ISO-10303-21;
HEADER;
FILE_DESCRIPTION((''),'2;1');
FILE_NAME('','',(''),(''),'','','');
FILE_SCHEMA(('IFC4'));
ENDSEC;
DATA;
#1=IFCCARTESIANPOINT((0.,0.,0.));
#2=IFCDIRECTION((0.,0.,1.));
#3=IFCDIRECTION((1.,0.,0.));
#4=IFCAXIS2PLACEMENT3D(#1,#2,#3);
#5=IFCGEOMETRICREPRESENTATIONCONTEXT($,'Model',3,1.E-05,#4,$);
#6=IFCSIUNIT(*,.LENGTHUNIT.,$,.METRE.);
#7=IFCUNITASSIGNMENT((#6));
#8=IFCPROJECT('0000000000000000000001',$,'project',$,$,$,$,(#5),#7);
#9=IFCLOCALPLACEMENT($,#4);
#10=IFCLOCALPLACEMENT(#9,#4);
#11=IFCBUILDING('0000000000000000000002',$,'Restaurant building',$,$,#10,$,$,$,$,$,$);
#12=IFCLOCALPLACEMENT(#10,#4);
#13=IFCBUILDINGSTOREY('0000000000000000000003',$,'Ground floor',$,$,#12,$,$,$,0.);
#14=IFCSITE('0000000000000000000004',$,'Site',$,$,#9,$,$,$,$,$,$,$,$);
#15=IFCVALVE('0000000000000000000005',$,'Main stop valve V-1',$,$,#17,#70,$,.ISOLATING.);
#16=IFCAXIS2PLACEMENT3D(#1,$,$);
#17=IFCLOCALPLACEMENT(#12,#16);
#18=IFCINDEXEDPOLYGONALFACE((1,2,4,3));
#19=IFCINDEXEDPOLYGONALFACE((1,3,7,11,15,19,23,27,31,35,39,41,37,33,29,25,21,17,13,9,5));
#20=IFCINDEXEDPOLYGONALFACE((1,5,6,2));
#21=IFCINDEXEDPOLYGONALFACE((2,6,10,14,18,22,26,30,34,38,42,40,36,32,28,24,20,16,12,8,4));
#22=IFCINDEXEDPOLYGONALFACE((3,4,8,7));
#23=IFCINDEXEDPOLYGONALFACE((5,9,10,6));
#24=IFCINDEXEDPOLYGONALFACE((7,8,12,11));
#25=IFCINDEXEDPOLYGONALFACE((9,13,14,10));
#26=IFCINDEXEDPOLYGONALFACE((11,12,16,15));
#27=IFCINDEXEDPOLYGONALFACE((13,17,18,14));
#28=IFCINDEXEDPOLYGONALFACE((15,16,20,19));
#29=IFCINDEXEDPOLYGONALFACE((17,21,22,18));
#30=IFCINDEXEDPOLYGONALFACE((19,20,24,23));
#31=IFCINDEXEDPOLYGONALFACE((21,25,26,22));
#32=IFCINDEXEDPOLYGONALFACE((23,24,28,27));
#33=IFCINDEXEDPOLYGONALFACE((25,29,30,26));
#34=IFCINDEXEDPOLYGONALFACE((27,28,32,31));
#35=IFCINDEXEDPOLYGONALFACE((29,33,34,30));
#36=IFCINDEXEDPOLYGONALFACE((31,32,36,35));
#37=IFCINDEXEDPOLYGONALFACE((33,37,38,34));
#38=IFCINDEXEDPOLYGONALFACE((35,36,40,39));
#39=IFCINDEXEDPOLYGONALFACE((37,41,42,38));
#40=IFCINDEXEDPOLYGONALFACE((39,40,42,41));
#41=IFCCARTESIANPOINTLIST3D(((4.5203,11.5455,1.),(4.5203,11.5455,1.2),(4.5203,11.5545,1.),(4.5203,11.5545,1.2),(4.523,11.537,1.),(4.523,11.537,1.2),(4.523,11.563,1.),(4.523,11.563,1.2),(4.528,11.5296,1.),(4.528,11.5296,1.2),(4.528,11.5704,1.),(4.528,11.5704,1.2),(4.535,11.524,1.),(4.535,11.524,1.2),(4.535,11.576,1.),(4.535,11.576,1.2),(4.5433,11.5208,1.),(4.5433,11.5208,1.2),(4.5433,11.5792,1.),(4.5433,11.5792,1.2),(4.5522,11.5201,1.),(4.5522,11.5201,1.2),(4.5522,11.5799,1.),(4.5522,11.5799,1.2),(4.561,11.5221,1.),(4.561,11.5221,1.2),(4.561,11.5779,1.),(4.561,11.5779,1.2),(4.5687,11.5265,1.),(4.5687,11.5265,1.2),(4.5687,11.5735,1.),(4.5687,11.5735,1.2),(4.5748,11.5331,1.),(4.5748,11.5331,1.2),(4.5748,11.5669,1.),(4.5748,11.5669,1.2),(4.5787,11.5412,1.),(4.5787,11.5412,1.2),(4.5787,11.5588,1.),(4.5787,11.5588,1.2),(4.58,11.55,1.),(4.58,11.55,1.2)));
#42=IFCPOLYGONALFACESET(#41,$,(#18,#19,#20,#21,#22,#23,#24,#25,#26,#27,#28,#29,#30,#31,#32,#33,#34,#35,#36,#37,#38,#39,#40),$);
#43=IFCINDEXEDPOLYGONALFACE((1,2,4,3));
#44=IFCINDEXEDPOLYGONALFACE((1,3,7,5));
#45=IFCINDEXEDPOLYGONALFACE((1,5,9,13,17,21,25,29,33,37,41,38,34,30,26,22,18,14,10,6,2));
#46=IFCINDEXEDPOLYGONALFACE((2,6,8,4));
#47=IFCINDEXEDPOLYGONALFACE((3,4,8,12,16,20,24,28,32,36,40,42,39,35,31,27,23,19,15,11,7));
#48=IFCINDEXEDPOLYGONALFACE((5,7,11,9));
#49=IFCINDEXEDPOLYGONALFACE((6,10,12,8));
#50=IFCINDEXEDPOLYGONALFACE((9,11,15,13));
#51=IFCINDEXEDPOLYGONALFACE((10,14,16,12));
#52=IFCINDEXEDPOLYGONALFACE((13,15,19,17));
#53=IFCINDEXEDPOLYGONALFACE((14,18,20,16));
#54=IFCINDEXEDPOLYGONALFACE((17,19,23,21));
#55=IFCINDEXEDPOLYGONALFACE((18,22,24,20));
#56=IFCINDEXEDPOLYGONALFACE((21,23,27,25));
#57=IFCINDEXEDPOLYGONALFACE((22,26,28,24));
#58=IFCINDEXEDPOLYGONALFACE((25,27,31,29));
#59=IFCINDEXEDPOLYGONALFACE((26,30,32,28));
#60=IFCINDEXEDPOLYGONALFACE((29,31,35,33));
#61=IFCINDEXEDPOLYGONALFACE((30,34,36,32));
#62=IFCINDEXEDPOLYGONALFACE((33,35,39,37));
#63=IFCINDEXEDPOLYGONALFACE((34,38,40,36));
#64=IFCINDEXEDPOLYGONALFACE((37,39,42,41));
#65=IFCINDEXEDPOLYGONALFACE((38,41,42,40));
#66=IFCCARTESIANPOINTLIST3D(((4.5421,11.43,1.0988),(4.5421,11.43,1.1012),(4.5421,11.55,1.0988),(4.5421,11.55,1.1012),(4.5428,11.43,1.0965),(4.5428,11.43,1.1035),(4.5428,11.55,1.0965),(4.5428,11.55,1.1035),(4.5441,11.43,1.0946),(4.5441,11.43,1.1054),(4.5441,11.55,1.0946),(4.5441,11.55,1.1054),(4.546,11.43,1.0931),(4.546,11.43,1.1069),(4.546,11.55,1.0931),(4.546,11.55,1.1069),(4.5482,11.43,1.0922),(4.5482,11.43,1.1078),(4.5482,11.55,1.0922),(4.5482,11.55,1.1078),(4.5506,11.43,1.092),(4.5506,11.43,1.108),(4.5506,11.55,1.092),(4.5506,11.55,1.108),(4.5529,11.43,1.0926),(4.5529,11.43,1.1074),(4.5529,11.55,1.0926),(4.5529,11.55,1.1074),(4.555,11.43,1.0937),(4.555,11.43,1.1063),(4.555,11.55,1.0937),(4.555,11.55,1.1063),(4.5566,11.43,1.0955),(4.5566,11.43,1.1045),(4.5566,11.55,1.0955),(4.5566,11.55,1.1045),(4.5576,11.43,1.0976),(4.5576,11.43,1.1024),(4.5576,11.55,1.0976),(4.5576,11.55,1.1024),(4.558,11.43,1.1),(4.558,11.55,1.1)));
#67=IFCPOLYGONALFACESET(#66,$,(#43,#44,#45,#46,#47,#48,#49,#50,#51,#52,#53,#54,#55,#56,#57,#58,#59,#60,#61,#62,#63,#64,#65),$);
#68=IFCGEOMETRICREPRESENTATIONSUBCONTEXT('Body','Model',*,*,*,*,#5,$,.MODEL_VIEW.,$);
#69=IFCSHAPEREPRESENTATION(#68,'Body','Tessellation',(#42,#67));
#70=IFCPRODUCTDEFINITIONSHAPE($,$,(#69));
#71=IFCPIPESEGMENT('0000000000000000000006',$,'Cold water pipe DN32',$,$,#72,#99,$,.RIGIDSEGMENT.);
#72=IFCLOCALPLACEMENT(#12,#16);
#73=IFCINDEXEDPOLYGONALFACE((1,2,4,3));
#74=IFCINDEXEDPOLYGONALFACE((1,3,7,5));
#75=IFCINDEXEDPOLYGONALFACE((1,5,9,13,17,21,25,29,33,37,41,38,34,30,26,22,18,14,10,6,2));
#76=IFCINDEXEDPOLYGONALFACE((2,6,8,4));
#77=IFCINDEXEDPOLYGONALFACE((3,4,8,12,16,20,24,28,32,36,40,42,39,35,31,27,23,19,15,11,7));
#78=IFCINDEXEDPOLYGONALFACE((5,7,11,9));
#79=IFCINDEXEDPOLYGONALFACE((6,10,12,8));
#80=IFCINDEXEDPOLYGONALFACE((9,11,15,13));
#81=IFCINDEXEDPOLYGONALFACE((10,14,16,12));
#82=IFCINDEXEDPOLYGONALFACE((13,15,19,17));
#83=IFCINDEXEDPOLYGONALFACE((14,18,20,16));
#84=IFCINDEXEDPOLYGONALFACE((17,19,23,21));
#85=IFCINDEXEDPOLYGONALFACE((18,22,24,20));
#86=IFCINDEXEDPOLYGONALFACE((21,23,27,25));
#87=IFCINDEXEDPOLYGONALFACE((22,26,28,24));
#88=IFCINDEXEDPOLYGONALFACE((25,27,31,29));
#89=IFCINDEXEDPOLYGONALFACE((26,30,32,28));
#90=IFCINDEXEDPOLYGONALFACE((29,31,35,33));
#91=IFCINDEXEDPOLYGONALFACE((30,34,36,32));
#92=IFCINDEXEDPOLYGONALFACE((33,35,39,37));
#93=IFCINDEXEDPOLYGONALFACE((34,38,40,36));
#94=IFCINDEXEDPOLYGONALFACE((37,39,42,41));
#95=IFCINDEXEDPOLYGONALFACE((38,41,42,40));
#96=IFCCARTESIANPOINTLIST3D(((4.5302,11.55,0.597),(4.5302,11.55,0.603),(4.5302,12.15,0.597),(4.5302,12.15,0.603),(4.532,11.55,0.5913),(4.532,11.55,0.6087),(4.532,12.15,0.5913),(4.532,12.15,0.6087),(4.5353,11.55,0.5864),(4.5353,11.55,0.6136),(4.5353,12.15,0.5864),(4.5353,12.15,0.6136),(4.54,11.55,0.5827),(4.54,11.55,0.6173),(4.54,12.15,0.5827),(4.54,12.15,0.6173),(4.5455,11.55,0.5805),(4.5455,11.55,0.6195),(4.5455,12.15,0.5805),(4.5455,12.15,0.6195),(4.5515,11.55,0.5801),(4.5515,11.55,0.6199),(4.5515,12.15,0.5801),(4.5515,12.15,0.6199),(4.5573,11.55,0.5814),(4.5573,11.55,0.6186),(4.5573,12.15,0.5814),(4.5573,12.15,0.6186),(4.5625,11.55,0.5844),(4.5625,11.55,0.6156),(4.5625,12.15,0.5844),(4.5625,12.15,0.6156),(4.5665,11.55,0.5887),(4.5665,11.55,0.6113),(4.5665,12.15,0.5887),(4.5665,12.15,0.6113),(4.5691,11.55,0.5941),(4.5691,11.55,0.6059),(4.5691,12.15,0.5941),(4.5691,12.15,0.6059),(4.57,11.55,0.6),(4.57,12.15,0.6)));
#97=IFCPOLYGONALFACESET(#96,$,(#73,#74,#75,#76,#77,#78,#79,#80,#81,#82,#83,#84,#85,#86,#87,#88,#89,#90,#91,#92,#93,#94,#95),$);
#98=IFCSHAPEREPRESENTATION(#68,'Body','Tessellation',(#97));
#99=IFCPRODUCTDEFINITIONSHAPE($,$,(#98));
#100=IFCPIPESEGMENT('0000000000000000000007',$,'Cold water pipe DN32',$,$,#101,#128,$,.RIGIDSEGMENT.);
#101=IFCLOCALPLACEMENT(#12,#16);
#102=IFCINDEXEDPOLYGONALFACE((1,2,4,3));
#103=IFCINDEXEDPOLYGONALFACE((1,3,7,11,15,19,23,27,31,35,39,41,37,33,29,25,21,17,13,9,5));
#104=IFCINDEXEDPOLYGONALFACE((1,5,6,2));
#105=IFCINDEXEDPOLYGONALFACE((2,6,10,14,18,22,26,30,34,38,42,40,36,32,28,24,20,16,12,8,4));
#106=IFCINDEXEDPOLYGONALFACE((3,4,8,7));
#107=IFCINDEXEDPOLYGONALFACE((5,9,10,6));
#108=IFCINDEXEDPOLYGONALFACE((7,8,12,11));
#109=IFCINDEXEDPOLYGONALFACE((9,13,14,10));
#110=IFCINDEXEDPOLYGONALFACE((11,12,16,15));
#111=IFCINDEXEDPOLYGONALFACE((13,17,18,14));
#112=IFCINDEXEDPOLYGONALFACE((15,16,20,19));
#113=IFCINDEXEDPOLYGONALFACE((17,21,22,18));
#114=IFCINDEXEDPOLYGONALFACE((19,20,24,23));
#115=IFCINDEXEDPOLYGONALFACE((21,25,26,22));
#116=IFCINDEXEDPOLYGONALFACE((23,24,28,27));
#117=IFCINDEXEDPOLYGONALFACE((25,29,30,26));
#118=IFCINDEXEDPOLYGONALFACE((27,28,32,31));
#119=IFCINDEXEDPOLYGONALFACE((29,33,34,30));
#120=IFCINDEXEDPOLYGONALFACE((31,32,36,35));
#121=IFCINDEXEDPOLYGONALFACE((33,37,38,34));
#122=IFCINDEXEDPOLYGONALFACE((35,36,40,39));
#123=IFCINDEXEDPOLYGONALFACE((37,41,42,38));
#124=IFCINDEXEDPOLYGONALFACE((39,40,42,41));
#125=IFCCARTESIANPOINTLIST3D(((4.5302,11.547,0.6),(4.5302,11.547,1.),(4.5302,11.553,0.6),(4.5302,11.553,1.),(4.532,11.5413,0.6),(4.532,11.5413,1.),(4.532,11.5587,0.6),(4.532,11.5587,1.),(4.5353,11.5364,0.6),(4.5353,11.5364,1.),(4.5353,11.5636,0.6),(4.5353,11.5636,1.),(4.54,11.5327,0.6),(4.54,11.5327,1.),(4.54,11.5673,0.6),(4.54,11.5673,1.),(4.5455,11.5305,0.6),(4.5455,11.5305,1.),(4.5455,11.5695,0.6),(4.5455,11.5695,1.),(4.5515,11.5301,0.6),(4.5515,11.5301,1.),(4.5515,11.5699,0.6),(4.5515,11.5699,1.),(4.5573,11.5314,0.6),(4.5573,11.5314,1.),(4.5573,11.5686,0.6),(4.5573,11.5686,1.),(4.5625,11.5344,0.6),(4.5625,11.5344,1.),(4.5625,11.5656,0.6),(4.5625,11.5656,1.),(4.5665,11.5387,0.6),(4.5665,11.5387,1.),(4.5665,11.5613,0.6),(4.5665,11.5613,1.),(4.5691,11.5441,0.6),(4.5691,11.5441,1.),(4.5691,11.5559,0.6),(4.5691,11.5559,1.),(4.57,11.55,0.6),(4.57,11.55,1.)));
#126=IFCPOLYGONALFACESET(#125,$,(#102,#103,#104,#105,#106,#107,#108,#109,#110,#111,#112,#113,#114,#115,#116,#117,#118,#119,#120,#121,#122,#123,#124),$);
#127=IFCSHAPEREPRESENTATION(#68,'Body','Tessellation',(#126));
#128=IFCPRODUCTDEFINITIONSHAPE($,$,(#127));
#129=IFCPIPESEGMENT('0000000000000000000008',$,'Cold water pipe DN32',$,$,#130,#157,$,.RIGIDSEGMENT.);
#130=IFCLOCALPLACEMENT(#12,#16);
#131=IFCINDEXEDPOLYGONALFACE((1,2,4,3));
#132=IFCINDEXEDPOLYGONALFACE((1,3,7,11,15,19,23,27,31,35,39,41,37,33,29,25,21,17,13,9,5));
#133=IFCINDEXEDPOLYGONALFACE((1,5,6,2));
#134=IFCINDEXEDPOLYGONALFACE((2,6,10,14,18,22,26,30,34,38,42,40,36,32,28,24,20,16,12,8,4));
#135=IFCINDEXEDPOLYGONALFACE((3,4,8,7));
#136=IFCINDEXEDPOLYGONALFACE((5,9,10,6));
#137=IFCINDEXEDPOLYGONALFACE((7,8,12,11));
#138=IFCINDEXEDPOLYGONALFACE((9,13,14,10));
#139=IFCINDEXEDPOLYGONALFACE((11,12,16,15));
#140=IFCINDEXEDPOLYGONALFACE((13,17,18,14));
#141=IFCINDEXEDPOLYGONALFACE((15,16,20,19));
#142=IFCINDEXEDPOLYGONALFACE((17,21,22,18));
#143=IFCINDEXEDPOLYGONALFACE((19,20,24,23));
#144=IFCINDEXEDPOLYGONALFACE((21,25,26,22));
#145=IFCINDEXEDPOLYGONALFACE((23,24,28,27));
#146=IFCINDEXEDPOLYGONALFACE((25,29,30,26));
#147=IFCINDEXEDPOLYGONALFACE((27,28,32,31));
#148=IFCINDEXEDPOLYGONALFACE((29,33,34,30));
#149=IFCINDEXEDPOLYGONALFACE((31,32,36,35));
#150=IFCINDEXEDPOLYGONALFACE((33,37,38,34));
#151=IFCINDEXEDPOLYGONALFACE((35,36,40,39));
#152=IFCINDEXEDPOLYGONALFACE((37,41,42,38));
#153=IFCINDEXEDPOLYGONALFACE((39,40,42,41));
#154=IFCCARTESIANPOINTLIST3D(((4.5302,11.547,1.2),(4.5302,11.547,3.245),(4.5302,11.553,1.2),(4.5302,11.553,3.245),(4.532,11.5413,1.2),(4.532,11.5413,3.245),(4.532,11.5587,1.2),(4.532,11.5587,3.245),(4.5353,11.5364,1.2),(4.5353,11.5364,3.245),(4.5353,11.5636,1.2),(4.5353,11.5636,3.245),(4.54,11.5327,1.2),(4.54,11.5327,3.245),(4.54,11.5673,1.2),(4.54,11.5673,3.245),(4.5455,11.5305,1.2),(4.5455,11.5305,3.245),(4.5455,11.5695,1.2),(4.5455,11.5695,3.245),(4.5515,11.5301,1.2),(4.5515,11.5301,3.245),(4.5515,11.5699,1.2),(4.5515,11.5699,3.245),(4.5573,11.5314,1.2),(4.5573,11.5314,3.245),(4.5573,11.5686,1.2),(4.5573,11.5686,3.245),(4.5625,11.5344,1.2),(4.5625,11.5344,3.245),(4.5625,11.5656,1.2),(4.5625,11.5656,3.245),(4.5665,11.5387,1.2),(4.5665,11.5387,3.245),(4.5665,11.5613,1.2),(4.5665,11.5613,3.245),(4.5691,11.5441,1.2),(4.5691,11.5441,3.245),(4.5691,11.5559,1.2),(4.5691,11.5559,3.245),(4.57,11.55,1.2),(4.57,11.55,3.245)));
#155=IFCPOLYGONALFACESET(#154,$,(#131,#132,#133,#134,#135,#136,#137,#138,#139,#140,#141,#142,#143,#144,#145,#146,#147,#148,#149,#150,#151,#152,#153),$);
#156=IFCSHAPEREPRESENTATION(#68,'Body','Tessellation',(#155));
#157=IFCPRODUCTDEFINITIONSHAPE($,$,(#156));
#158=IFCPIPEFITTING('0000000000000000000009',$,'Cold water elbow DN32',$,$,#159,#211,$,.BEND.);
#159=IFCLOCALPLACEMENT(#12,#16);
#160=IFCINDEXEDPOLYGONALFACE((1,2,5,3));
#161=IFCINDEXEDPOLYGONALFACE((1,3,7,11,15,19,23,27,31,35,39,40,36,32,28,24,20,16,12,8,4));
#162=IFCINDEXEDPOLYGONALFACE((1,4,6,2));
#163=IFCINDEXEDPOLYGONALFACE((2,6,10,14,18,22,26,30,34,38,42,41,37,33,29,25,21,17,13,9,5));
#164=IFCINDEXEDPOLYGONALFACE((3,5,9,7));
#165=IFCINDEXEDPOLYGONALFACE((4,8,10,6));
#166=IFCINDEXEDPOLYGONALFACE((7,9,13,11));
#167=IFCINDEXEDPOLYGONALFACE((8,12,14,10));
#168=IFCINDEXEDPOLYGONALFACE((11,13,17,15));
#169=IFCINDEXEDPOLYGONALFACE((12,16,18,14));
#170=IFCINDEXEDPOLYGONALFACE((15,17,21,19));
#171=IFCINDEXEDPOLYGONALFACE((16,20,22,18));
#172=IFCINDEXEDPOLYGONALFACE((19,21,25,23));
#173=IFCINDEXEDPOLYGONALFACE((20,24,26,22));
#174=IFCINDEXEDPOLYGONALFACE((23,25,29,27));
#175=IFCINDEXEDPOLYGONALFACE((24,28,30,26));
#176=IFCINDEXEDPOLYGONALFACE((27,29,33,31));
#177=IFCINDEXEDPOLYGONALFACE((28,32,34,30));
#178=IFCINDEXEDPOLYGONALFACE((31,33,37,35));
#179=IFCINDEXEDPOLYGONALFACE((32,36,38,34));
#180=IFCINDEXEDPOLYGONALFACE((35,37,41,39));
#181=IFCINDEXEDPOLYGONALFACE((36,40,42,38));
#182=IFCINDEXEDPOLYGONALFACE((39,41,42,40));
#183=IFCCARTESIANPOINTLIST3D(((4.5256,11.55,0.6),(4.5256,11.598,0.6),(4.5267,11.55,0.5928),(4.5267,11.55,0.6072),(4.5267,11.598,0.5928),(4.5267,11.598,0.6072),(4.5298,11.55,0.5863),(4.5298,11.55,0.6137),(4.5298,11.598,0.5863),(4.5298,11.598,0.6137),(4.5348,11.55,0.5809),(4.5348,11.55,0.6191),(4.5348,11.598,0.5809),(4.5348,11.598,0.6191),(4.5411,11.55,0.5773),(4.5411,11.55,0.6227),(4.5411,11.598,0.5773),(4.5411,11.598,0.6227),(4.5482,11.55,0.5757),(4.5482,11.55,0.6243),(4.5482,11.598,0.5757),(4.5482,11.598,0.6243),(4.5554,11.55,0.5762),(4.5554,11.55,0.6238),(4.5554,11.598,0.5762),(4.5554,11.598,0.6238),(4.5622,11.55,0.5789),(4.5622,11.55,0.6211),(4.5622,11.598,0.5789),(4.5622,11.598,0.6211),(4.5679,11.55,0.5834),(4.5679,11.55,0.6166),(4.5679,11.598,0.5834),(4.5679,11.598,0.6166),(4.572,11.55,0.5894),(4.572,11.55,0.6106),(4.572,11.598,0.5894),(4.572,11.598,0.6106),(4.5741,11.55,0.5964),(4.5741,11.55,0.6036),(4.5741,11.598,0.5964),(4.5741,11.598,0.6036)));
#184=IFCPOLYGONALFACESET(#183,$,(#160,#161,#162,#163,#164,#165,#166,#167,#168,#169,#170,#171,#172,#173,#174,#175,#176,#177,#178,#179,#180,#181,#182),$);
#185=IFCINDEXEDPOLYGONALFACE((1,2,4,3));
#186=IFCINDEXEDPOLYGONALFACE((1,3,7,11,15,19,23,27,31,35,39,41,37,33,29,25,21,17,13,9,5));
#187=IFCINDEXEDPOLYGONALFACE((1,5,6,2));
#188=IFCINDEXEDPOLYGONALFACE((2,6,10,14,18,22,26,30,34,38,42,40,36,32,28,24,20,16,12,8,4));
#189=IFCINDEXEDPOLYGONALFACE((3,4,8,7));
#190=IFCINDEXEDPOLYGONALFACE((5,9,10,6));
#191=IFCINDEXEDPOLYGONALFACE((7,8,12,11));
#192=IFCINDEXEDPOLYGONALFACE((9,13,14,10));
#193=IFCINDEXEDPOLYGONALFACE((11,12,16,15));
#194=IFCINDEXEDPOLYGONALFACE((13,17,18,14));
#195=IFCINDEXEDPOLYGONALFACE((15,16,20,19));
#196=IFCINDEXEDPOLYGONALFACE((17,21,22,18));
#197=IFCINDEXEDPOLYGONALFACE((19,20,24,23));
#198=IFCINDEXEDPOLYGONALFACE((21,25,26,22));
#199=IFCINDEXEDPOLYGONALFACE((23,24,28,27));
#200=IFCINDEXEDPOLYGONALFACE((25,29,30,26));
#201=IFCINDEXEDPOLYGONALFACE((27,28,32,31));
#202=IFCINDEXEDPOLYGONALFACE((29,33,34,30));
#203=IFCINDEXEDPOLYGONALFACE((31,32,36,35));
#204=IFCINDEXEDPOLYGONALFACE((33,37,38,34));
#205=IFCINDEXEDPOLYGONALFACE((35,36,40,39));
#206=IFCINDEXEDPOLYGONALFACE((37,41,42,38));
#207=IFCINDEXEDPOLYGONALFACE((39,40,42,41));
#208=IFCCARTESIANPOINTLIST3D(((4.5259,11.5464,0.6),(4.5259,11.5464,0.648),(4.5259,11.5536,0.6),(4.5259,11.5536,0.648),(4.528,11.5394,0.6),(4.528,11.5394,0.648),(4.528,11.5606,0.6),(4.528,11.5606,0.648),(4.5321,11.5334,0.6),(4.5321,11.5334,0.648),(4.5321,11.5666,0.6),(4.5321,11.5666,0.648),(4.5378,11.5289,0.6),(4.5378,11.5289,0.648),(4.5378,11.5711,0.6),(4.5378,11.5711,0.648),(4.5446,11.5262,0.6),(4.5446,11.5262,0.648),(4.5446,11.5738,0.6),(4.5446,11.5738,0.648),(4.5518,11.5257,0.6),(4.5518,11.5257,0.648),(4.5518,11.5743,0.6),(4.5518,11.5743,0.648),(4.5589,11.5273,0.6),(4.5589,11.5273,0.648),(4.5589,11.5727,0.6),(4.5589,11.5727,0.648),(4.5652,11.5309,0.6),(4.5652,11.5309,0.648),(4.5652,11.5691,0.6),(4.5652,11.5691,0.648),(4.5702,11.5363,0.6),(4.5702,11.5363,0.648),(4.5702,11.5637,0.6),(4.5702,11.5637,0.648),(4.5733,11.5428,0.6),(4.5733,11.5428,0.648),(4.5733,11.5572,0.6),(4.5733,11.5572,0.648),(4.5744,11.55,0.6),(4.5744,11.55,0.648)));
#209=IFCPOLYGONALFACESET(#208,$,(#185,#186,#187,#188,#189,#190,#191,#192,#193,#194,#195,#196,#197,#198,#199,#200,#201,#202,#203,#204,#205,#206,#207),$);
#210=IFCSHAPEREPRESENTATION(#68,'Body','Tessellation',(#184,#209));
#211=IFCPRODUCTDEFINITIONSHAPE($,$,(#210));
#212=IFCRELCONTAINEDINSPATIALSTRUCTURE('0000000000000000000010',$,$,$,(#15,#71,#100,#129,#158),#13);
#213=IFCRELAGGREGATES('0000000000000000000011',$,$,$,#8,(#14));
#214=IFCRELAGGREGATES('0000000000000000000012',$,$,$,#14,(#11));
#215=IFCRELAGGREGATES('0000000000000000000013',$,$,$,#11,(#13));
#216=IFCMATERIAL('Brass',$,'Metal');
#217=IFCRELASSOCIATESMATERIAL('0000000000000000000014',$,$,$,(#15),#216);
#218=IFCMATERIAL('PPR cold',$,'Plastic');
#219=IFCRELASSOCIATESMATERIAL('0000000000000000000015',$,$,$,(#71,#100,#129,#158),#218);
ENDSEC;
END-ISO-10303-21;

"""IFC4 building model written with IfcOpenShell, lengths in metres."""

from ifc_helpers import new_model, si_unit, frame, origin, origin_with_axes, origin_2d, place, context, subcontext, project, spatial, circle, extrude, material, element, save


model = new_model("IFC4")

# Units and contexts
model_context = context("Model", 3, precision=1e-05, world=origin_with_axes())
body_context = subcontext(model_context, "Body", "Model", "MODEL_VIEW")
ifc_project = project(units=[si_unit("LENGTHUNIT", "METRE")], contexts=[model_context])

# Site, building, storey
site_placement = place(None, origin_with_axes())
site = spatial("IfcSite", under=ifc_project, at=site_placement, Name="Site")
building_placement = place(site_placement, origin_with_axes())
building = spatial("IfcBuilding", under=site, at=building_placement, Name="Restaurant building")
storey_placement = place(building_placement, origin_with_axes())
storey = spatial("IfcBuildingStorey", under=building, at=storey_placement, Name="Ground floor", Elevation=0.0)

# Shared definitions
ifc_material_1 = material(Name="Brass", Category="Metal")

# Valve
valve_1_placement = place(storey_placement, frame((4.55, 11.55, 0.0)))
element("IfcValve", 1, at=valve_1_placement, inside=storey, material=ifc_material_1, Name="Main stop valve V-1", PredefinedType="ISOLATING", context=body_context, shape_type="SweptSolid", body=[
    extrude(circle(Radius=0.03, at=origin_2d()), frame((0.0, 0.0, 1.0)), (0.0, 0.0, 1.0), 0.2),
    extrude(circle(Radius=0.008, at=origin_2d()), frame((0.0, 0.0, 1.1), z_axis=(0.0, -1.0, 0.0), x_axis=(1.0, 0.0, 0.0)), (0.0, 0.0, 1.0), 0.12),
])

# Pipe segments
ifc_material_2 = material(Name="PPR cold", Category="Plastic")
pipe_segment_1_placement = place(storey_placement, frame((4.55, 12.15, 0.6)))
element("IfcPipeSegment", 2, at=pipe_segment_1_placement, inside=storey, material=ifc_material_2, Name="Cold water pipe DN32", PredefinedType="RIGIDSEGMENT", context=body_context, shape_type="SweptSolid", body=[
    extrude(circle(Radius=0.02, at=origin_2d()), frame((0.0, 0.0, 0.0), z_axis=(0.0, -1.0, 0.0), x_axis=(1.0, 0.0, 0.0)), (0.0, 0.0, 1.0), 0.6),
])
pipe_segment_2_placement = place(storey_placement, frame((4.55, 11.55, 0.6)))
element("IfcPipeSegment", 3, at=pipe_segment_2_placement, inside=storey, material=ifc_material_2, Name="Cold water pipe DN32", PredefinedType="RIGIDSEGMENT", context=body_context, shape_type="SweptSolid", body=[
    extrude(circle(Radius=0.02, at=origin_2d()), origin(), (0.0, 0.0, 1.0), 0.4),
])
pipe_segment_3_placement = place(storey_placement, frame((4.55, 11.55, 1.2)))
element("IfcPipeSegment", 4, at=pipe_segment_3_placement, inside=storey, material=ifc_material_2, Name="Cold water pipe DN32", PredefinedType="RIGIDSEGMENT", context=body_context, shape_type="SweptSolid", body=[
    extrude(circle(Radius=0.02, at=origin_2d()), origin(), (0.0, 0.0, 1.0), 2.045),
])

# Pipe fitting
pipe_fitting_1_placement = place(storey_placement, frame((4.55, 11.55, 0.6)))
element("IfcPipeFitting", 5, at=pipe_fitting_1_placement, inside=storey, material=ifc_material_2, Name="Cold water elbow DN32", PredefinedType="BEND", context=body_context, shape_type="SweptSolid", body=[
    extrude(circle(Radius=0.0244, at=origin_2d()), frame((0.0, 0.0, 0.0), z_axis=(0.0, 1.0, 0.0), x_axis=(-1.0, 0.0, 0.0)), (0.0, 0.0, 1.0), 0.048),
    extrude(circle(Radius=0.0244, at=origin_2d()), origin(), (0.0, 0.0, 1.0), 0.048),
])

save(model, "model.ifc")
